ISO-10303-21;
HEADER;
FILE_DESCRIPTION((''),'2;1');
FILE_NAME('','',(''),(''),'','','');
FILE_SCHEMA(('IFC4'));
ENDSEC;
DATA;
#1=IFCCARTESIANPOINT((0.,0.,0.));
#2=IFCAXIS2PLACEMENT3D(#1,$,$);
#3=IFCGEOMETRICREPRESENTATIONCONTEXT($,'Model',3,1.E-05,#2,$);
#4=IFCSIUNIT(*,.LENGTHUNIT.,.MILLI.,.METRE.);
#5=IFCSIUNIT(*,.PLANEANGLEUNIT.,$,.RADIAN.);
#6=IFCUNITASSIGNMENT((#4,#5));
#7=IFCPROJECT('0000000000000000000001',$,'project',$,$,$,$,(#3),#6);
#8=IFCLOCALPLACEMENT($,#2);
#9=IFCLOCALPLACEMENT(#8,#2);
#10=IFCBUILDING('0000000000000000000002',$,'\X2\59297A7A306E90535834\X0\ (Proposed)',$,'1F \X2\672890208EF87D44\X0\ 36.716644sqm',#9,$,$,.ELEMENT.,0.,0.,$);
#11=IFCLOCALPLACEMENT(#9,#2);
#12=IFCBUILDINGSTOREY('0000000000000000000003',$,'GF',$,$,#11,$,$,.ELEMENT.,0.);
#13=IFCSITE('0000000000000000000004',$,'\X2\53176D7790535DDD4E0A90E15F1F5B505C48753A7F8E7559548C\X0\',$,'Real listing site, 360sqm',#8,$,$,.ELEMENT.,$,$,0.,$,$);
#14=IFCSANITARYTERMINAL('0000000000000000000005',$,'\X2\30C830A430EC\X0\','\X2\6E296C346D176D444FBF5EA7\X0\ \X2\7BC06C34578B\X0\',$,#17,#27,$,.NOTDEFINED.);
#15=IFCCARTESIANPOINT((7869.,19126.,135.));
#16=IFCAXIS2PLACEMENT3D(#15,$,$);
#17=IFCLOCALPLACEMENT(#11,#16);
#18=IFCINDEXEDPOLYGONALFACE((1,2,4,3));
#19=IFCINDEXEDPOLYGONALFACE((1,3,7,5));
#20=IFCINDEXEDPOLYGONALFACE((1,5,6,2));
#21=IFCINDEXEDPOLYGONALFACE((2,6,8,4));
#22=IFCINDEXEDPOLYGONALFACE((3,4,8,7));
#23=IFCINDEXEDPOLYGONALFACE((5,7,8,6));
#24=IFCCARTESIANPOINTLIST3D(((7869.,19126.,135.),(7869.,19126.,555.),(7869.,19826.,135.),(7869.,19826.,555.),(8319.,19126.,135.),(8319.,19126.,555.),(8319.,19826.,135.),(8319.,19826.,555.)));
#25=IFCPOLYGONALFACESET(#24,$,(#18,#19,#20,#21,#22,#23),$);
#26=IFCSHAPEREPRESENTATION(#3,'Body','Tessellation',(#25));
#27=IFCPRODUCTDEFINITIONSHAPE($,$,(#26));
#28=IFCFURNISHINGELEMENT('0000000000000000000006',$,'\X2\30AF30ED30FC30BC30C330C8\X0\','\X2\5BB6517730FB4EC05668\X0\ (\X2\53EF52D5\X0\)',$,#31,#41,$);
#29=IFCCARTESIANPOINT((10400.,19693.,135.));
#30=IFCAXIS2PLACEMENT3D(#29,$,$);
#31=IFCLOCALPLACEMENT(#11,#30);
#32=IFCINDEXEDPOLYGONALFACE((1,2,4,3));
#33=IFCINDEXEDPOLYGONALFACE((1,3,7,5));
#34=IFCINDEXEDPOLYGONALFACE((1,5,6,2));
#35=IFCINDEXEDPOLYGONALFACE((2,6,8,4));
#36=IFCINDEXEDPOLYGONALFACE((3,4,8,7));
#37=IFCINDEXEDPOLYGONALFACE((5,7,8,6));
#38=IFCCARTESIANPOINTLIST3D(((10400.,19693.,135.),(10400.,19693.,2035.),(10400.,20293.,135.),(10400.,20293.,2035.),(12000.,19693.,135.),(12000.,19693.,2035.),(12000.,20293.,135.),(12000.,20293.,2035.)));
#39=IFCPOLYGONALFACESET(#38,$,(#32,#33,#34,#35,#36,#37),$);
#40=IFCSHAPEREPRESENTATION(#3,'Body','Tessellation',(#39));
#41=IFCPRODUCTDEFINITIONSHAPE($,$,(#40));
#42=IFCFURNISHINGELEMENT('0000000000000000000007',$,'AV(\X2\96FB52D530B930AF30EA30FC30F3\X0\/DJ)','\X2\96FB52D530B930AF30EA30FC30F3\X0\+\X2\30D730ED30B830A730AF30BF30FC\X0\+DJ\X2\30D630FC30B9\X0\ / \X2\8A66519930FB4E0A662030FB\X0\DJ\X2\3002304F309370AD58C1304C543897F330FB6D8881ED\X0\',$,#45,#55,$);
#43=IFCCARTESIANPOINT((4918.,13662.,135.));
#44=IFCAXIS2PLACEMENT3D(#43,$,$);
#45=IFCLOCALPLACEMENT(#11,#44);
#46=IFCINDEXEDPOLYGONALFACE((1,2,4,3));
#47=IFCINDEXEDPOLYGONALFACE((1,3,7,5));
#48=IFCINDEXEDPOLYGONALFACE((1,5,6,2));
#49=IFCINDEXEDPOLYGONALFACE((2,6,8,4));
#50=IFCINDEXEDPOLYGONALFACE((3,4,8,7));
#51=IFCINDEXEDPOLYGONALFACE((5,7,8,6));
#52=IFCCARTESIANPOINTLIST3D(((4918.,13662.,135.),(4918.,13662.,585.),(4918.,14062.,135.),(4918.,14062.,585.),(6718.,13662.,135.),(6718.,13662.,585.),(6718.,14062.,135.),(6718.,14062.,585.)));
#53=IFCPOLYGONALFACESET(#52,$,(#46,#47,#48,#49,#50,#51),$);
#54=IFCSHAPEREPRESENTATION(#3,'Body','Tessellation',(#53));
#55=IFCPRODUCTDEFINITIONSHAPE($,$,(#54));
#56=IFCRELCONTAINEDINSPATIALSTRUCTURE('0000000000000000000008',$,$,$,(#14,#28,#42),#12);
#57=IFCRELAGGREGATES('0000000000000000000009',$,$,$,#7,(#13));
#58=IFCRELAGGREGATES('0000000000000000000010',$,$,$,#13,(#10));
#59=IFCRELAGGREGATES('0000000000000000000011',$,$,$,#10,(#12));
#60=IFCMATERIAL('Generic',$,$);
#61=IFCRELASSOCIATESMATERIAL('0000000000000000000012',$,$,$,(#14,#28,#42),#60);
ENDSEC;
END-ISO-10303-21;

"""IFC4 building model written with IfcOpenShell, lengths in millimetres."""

from ifc_helpers import new_model, si_unit, frame, frame_2d, origin, place, context, project, spatial, rectangle, extrude, material, element, save


model = new_model("IFC4")

# Units and contexts
model_context = context("Model", 3, precision=1e-05, world=origin())
ifc_project = project(units=[si_unit("LENGTHUNIT", "METRE", prefix="MILLI"), si_unit("PLANEANGLEUNIT", "RADIAN")], contexts=[model_context])

# Site, building, storey
site_placement = place(None, origin())
site = spatial("IfcSite", under=ifc_project, at=site_placement, Name="北海道川上郡弟子屈町美留和", ObjectType="Real listing site, 360sqm", CompositionType="ELEMENT", RefElevation=0.0)
building_placement = place(site_placement, origin())
building = spatial("IfcBuilding", under=site, at=building_placement, Name="天空の道場 (Proposed)", ObjectType="1F 木造軸組 36.716644sqm", CompositionType="ELEMENT", ElevationOfRefHeight=0.0, ElevationOfTerrain=0.0)
storey_placement = place(building_placement, origin())
storey = spatial("IfcBuildingStorey", under=building, at=storey_placement, Name="GF", CompositionType="ELEMENT", Elevation=0.0)

# Shared definitions
ifc_material_1 = material(Name="Generic")

# Sanitary terminal
sanitary_terminal_1_placement = place(storey_placement, frame((7869.0, 19126.0, 135.0)))
element("IfcSanitaryTerminal", 1, at=sanitary_terminal_1_placement, inside=storey, material=ifc_material_1, Name="トイレ", Description="温水洗浄便座 節水型", PredefinedType="NOTDEFINED", context=model_context, shape_type="SweptSolid", body=[
    extrude(rectangle(XDim=450.0, YDim=700.0, at=frame_2d((225.0, 350.0))), frame((7869.0, 19126.0, 135.0)), (0.0, 0.0, 1.0), 420.0),
])

# Furnishing elements
furnishing_1_placement = place(storey_placement, frame((10400.0, 19693.0, 135.0)))
element("IfcFurnishingElement", 2, at=furnishing_1_placement, inside=storey, material=ifc_material_1, Name="クローゼット", Description="家具・什器 (可動)", context=model_context, shape_type="SweptSolid", body=[
    extrude(rectangle(XDim=1600.0, YDim=600.0, at=frame_2d((800.0, 300.0))), frame((10400.0, 19693.0, 135.0)), (0.0, 0.0, 1.0), 1900.0),
])
furnishing_2_placement = place(storey_placement, frame((4918.0, 13662.0, 135.0)))
element("IfcFurnishingElement", 3, at=furnishing_2_placement, inside=storey, material=ifc_material_1, Name="AV(電動スクリーン/DJ)", Description="電動スクリーン+プロジェクター+DJブース / 試写・上映・DJ。くん炭壁が吸音・消臭", context=model_context, shape_type="SweptSolid", body=[
    extrude(rectangle(XDim=1800.0, YDim=400.0, at=frame_2d((900.0, 200.0))), frame((4918.0, 13662.0, 135.0)), (0.0, 0.0, 1.0), 450.0),
])

save(model, "model.ifc")
